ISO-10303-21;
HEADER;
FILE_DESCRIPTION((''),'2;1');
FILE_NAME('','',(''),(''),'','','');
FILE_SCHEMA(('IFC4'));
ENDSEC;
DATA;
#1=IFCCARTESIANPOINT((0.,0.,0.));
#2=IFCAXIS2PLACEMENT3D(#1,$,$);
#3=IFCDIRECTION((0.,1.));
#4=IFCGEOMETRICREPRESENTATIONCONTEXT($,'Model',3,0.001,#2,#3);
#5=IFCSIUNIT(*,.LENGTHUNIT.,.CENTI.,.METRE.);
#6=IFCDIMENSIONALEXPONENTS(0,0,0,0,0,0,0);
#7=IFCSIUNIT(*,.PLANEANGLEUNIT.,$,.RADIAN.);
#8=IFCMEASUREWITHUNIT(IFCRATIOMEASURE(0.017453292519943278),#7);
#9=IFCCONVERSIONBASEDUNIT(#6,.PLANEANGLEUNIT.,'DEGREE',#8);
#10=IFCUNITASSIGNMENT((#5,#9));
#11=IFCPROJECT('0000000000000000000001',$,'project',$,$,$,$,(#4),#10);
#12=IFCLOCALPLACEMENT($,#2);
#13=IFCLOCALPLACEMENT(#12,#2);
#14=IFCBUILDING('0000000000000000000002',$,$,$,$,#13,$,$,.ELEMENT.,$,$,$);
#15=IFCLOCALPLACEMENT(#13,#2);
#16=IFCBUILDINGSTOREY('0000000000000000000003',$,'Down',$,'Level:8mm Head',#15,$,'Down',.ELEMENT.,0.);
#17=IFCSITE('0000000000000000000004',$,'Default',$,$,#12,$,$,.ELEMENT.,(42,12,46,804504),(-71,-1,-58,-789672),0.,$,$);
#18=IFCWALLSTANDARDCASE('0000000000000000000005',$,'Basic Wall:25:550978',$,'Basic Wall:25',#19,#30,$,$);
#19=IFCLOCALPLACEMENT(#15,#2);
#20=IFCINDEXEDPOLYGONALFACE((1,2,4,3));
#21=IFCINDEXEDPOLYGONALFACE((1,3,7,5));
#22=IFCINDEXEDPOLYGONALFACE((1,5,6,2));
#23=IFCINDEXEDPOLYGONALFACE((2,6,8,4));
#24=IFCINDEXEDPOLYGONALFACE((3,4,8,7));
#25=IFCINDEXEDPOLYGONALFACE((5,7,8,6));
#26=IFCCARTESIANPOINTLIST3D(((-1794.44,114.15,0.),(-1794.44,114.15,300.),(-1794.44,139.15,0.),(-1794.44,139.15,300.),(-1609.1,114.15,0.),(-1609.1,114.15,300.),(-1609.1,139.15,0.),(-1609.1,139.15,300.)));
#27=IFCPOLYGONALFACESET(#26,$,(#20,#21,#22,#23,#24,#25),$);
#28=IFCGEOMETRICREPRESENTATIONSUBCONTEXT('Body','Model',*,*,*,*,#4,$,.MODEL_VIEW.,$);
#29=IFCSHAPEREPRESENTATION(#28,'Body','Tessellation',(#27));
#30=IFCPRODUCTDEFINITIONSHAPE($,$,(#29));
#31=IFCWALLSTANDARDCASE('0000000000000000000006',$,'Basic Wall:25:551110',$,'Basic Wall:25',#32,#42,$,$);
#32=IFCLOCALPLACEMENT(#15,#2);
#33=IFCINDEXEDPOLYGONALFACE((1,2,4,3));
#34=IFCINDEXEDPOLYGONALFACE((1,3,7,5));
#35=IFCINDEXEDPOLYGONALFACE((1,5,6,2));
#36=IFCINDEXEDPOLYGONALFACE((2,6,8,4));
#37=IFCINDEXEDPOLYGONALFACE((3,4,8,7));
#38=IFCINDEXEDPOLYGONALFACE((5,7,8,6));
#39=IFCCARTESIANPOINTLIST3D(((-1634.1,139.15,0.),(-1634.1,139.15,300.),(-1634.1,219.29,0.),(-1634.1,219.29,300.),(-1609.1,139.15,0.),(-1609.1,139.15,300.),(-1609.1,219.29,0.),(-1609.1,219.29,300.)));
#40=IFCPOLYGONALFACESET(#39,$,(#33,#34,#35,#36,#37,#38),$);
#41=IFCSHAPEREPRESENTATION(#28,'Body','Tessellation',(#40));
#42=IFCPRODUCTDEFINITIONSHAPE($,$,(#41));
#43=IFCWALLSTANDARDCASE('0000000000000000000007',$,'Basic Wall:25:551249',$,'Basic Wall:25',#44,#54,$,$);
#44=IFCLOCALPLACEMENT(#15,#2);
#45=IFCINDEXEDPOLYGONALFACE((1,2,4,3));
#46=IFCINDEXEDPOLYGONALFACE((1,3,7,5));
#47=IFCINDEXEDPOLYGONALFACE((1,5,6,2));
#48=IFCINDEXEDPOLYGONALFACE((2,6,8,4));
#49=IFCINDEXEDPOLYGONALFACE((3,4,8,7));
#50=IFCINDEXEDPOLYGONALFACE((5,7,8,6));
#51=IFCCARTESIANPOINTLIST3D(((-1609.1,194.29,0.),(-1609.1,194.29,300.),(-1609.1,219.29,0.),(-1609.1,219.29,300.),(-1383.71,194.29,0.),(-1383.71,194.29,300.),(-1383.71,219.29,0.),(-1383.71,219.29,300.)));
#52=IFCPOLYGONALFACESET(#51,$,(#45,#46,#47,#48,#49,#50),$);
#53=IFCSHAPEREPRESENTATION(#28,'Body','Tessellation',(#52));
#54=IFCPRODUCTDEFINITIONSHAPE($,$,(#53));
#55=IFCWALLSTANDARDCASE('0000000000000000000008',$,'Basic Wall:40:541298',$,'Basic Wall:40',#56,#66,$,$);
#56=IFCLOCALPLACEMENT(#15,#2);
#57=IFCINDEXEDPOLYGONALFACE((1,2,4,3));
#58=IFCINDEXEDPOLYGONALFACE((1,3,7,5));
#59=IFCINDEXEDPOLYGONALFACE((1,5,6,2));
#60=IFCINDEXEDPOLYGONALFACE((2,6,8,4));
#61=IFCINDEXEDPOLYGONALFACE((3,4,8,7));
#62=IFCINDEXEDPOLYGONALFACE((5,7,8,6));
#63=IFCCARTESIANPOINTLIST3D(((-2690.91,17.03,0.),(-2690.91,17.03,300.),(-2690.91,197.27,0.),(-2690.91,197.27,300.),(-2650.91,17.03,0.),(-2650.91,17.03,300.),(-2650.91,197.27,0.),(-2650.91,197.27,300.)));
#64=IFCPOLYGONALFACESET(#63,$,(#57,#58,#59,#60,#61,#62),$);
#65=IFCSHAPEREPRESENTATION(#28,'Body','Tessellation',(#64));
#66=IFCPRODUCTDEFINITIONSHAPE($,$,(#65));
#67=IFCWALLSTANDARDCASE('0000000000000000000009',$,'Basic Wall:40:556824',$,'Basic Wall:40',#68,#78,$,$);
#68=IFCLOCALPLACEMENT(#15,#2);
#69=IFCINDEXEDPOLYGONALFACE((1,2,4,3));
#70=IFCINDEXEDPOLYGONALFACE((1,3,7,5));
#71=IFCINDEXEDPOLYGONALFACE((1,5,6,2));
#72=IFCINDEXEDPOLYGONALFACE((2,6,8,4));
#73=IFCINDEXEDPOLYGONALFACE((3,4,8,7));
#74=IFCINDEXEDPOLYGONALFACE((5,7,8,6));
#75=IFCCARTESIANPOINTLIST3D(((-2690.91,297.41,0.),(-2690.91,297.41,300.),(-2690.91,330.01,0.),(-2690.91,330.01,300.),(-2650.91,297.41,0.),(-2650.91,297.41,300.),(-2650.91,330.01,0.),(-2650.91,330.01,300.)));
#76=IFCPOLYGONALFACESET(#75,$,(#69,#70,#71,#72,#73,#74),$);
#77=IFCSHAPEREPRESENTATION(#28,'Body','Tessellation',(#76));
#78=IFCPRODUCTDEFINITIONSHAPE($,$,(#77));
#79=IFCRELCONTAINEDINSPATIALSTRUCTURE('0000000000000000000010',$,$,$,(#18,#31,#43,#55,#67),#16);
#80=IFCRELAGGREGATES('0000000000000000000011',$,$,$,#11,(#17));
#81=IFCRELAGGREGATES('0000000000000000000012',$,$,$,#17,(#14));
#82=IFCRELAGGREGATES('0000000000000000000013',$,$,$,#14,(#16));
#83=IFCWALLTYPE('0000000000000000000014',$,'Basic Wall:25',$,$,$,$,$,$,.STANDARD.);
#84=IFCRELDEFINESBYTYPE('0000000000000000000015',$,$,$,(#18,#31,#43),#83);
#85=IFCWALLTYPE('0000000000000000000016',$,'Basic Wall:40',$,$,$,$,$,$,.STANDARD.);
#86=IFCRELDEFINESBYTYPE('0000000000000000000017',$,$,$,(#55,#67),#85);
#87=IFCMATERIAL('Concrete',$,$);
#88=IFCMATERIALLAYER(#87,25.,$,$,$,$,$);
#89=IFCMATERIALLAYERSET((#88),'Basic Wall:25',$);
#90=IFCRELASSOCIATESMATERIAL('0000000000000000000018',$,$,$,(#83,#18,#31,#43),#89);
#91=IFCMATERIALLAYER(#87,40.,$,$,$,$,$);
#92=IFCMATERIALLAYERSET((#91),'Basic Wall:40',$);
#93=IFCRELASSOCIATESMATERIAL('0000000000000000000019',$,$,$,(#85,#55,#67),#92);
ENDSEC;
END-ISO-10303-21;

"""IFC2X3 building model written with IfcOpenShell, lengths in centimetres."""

from ifc_helpers import new_model, entity, si_unit, converted_unit, direction, frame, frame_2d, origin, place, context, subcontext, project, spatial, rectangle, extrude, material, layer, layer_set, layer_usage, type_object, element, save


model = new_model("IFC2X3")

# Units and contexts
model_context = context("Model", 3, precision=0.001, world=origin(), true_north=direction((0.0, 1.0)))
body_context = subcontext(model_context, "Body", "Model", "MODEL_VIEW")
ifc_project = project(units=[si_unit("LENGTHUNIT", "METRE", prefix="CENTI"), converted_unit("PLANEANGLEUNIT", "DEGREE", entity("IfcRatioMeasure", 0.017453292519943278), si_unit("PLANEANGLEUNIT", "RADIAN"), dimensions=[0, 0, 0, 0, 0, 0, 0])], contexts=[model_context])

# Site, building, storey
site_placement = place(None, origin())
site = spatial("IfcSite", under=ifc_project, at=site_placement, Name="Default", CompositionType="ELEMENT", RefLatitude=(42, 12, 46, 804504), RefLongitude=(-71, -1, -58, -789672), RefElevation=0.0)
building_placement = place(site_placement, origin())
building = spatial("IfcBuilding", under=site, at=building_placement, CompositionType="ELEMENT")
storey_placement = place(building_placement, origin())
storey = spatial("IfcBuildingStorey", under=building, at=storey_placement, Name="Down", ObjectType="Level:8mm Head", LongName="Down", CompositionType="ELEMENT", Elevation=0.0)

# Walls
ifc_material = material(Name="Concrete")
ifc_layer_1 = layer(ifc_material, 25.0)
ifc_layer_set_1 = layer_set([ifc_layer_1], Name="Basic Wall:25")
wall_type_1 = type_object("IfcWallType", Name="Basic Wall:25", PredefinedType="STANDARD", material=ifc_layer_set_1)
ifc_layer_usage_1 = layer_usage(ifc_layer_set_1, "AXIS2", "NEGATIVE", 12.5)
wall_1_placement = place(storey_placement, frame((-1794.44, 126.65, 0.0)))
element("IfcWallStandardCase", 1, at=wall_1_placement, inside=storey, type_object=wall_type_1, material=ifc_layer_usage_1, Name="Basic Wall:25:550978", ObjectType="Basic Wall:25", context=body_context, shape_type="SweptSolid", body=[
    extrude(rectangle(XDim=185.34, YDim=25.0, at=frame_2d((92.67, 0.0), x_axis=(-1.0, 0.0))), origin(), (0.0, 0.0, 1.0), 300.0),
])
ifc_layer_usage_2 = layer_usage(ifc_layer_set_1, "AXIS2", "POSITIVE", -12.5)
wall_2_placement = place(storey_placement, frame((-1621.6, 139.15, 0.0), z_axis=(0.0, 0.0, 1.0), x_axis=(0.0, 1.0, 0.0)))
element("IfcWallStandardCase", 2, at=wall_2_placement, inside=storey, type_object=wall_type_1, material=ifc_layer_usage_2, Name="Basic Wall:25:551110", ObjectType="Basic Wall:25", context=body_context, shape_type="SweptSolid", body=[
    extrude(rectangle(XDim=80.15, YDim=25.0, at=frame_2d((40.07, 0.0), x_axis=(-1.0, 0.0))), origin(), (0.0, 0.0, 1.0), 300.0),
])
ifc_layer_usage_3 = layer_usage(ifc_layer_set_1, "AXIS2", "NEGATIVE", 12.5)
wall_3_placement = place(storey_placement, frame((-1609.1, 206.79, 0.0)))
element("IfcWallStandardCase", 3, at=wall_3_placement, inside=storey, type_object=wall_type_1, material=ifc_layer_usage_3, Name="Basic Wall:25:551249", ObjectType="Basic Wall:25", context=body_context, shape_type="SweptSolid", body=[
    extrude(rectangle(XDim=225.39, YDim=25.0, at=frame_2d((112.7, 0.0), x_axis=(-1.0, 0.0))), origin(), (0.0, 0.0, 1.0), 300.0),
])
ifc_layer_2 = layer(ifc_material, 40.0)
ifc_layer_set_2 = layer_set([ifc_layer_2], Name="Basic Wall:40")
ifc_layer_usage_4 = layer_usage(ifc_layer_set_2, "AXIS2", "NEGATIVE", 20.0)
wall_type_2 = type_object("IfcWallType", Name="Basic Wall:40", PredefinedType="STANDARD", material=ifc_layer_set_2)
wall_4_placement = place(storey_placement, frame((-2670.91, 17.03, 0.0), z_axis=(0.0, 0.0, 1.0), x_axis=(0.0, 1.0, 0.0)))
element("IfcWallStandardCase", 4, at=wall_4_placement, inside=storey, type_object=wall_type_2, material=ifc_layer_usage_4, Name="Basic Wall:40:541298", ObjectType="Basic Wall:40", context=body_context, shape_type="SweptSolid", body=[
    extrude(rectangle(XDim=180.24, YDim=40.0, at=frame_2d((90.12, 0.0), x_axis=(-1.0, 0.0))), origin(), (0.0, 0.0, 1.0), 300.0),
])
ifc_layer_usage_5 = layer_usage(ifc_layer_set_2, "AXIS2", "NEGATIVE", 20.0)
wall_5_placement = place(storey_placement, frame((-2670.91, 297.41, 0.0), z_axis=(0.0, 0.0, 1.0), x_axis=(0.0, 1.0, 0.0)))
element("IfcWallStandardCase", 5, at=wall_5_placement, inside=storey, type_object=wall_type_2, material=ifc_layer_usage_5, Name="Basic Wall:40:556824", ObjectType="Basic Wall:40", context=body_context, shape_type="SweptSolid", body=[
    extrude(rectangle(XDim=32.6, YDim=40.0, at=frame_2d((16.3, 0.0), x_axis=(-1.0, 0.0))), origin(), (0.0, 0.0, 1.0), 300.0),
])

save(model, "model.ifc")
